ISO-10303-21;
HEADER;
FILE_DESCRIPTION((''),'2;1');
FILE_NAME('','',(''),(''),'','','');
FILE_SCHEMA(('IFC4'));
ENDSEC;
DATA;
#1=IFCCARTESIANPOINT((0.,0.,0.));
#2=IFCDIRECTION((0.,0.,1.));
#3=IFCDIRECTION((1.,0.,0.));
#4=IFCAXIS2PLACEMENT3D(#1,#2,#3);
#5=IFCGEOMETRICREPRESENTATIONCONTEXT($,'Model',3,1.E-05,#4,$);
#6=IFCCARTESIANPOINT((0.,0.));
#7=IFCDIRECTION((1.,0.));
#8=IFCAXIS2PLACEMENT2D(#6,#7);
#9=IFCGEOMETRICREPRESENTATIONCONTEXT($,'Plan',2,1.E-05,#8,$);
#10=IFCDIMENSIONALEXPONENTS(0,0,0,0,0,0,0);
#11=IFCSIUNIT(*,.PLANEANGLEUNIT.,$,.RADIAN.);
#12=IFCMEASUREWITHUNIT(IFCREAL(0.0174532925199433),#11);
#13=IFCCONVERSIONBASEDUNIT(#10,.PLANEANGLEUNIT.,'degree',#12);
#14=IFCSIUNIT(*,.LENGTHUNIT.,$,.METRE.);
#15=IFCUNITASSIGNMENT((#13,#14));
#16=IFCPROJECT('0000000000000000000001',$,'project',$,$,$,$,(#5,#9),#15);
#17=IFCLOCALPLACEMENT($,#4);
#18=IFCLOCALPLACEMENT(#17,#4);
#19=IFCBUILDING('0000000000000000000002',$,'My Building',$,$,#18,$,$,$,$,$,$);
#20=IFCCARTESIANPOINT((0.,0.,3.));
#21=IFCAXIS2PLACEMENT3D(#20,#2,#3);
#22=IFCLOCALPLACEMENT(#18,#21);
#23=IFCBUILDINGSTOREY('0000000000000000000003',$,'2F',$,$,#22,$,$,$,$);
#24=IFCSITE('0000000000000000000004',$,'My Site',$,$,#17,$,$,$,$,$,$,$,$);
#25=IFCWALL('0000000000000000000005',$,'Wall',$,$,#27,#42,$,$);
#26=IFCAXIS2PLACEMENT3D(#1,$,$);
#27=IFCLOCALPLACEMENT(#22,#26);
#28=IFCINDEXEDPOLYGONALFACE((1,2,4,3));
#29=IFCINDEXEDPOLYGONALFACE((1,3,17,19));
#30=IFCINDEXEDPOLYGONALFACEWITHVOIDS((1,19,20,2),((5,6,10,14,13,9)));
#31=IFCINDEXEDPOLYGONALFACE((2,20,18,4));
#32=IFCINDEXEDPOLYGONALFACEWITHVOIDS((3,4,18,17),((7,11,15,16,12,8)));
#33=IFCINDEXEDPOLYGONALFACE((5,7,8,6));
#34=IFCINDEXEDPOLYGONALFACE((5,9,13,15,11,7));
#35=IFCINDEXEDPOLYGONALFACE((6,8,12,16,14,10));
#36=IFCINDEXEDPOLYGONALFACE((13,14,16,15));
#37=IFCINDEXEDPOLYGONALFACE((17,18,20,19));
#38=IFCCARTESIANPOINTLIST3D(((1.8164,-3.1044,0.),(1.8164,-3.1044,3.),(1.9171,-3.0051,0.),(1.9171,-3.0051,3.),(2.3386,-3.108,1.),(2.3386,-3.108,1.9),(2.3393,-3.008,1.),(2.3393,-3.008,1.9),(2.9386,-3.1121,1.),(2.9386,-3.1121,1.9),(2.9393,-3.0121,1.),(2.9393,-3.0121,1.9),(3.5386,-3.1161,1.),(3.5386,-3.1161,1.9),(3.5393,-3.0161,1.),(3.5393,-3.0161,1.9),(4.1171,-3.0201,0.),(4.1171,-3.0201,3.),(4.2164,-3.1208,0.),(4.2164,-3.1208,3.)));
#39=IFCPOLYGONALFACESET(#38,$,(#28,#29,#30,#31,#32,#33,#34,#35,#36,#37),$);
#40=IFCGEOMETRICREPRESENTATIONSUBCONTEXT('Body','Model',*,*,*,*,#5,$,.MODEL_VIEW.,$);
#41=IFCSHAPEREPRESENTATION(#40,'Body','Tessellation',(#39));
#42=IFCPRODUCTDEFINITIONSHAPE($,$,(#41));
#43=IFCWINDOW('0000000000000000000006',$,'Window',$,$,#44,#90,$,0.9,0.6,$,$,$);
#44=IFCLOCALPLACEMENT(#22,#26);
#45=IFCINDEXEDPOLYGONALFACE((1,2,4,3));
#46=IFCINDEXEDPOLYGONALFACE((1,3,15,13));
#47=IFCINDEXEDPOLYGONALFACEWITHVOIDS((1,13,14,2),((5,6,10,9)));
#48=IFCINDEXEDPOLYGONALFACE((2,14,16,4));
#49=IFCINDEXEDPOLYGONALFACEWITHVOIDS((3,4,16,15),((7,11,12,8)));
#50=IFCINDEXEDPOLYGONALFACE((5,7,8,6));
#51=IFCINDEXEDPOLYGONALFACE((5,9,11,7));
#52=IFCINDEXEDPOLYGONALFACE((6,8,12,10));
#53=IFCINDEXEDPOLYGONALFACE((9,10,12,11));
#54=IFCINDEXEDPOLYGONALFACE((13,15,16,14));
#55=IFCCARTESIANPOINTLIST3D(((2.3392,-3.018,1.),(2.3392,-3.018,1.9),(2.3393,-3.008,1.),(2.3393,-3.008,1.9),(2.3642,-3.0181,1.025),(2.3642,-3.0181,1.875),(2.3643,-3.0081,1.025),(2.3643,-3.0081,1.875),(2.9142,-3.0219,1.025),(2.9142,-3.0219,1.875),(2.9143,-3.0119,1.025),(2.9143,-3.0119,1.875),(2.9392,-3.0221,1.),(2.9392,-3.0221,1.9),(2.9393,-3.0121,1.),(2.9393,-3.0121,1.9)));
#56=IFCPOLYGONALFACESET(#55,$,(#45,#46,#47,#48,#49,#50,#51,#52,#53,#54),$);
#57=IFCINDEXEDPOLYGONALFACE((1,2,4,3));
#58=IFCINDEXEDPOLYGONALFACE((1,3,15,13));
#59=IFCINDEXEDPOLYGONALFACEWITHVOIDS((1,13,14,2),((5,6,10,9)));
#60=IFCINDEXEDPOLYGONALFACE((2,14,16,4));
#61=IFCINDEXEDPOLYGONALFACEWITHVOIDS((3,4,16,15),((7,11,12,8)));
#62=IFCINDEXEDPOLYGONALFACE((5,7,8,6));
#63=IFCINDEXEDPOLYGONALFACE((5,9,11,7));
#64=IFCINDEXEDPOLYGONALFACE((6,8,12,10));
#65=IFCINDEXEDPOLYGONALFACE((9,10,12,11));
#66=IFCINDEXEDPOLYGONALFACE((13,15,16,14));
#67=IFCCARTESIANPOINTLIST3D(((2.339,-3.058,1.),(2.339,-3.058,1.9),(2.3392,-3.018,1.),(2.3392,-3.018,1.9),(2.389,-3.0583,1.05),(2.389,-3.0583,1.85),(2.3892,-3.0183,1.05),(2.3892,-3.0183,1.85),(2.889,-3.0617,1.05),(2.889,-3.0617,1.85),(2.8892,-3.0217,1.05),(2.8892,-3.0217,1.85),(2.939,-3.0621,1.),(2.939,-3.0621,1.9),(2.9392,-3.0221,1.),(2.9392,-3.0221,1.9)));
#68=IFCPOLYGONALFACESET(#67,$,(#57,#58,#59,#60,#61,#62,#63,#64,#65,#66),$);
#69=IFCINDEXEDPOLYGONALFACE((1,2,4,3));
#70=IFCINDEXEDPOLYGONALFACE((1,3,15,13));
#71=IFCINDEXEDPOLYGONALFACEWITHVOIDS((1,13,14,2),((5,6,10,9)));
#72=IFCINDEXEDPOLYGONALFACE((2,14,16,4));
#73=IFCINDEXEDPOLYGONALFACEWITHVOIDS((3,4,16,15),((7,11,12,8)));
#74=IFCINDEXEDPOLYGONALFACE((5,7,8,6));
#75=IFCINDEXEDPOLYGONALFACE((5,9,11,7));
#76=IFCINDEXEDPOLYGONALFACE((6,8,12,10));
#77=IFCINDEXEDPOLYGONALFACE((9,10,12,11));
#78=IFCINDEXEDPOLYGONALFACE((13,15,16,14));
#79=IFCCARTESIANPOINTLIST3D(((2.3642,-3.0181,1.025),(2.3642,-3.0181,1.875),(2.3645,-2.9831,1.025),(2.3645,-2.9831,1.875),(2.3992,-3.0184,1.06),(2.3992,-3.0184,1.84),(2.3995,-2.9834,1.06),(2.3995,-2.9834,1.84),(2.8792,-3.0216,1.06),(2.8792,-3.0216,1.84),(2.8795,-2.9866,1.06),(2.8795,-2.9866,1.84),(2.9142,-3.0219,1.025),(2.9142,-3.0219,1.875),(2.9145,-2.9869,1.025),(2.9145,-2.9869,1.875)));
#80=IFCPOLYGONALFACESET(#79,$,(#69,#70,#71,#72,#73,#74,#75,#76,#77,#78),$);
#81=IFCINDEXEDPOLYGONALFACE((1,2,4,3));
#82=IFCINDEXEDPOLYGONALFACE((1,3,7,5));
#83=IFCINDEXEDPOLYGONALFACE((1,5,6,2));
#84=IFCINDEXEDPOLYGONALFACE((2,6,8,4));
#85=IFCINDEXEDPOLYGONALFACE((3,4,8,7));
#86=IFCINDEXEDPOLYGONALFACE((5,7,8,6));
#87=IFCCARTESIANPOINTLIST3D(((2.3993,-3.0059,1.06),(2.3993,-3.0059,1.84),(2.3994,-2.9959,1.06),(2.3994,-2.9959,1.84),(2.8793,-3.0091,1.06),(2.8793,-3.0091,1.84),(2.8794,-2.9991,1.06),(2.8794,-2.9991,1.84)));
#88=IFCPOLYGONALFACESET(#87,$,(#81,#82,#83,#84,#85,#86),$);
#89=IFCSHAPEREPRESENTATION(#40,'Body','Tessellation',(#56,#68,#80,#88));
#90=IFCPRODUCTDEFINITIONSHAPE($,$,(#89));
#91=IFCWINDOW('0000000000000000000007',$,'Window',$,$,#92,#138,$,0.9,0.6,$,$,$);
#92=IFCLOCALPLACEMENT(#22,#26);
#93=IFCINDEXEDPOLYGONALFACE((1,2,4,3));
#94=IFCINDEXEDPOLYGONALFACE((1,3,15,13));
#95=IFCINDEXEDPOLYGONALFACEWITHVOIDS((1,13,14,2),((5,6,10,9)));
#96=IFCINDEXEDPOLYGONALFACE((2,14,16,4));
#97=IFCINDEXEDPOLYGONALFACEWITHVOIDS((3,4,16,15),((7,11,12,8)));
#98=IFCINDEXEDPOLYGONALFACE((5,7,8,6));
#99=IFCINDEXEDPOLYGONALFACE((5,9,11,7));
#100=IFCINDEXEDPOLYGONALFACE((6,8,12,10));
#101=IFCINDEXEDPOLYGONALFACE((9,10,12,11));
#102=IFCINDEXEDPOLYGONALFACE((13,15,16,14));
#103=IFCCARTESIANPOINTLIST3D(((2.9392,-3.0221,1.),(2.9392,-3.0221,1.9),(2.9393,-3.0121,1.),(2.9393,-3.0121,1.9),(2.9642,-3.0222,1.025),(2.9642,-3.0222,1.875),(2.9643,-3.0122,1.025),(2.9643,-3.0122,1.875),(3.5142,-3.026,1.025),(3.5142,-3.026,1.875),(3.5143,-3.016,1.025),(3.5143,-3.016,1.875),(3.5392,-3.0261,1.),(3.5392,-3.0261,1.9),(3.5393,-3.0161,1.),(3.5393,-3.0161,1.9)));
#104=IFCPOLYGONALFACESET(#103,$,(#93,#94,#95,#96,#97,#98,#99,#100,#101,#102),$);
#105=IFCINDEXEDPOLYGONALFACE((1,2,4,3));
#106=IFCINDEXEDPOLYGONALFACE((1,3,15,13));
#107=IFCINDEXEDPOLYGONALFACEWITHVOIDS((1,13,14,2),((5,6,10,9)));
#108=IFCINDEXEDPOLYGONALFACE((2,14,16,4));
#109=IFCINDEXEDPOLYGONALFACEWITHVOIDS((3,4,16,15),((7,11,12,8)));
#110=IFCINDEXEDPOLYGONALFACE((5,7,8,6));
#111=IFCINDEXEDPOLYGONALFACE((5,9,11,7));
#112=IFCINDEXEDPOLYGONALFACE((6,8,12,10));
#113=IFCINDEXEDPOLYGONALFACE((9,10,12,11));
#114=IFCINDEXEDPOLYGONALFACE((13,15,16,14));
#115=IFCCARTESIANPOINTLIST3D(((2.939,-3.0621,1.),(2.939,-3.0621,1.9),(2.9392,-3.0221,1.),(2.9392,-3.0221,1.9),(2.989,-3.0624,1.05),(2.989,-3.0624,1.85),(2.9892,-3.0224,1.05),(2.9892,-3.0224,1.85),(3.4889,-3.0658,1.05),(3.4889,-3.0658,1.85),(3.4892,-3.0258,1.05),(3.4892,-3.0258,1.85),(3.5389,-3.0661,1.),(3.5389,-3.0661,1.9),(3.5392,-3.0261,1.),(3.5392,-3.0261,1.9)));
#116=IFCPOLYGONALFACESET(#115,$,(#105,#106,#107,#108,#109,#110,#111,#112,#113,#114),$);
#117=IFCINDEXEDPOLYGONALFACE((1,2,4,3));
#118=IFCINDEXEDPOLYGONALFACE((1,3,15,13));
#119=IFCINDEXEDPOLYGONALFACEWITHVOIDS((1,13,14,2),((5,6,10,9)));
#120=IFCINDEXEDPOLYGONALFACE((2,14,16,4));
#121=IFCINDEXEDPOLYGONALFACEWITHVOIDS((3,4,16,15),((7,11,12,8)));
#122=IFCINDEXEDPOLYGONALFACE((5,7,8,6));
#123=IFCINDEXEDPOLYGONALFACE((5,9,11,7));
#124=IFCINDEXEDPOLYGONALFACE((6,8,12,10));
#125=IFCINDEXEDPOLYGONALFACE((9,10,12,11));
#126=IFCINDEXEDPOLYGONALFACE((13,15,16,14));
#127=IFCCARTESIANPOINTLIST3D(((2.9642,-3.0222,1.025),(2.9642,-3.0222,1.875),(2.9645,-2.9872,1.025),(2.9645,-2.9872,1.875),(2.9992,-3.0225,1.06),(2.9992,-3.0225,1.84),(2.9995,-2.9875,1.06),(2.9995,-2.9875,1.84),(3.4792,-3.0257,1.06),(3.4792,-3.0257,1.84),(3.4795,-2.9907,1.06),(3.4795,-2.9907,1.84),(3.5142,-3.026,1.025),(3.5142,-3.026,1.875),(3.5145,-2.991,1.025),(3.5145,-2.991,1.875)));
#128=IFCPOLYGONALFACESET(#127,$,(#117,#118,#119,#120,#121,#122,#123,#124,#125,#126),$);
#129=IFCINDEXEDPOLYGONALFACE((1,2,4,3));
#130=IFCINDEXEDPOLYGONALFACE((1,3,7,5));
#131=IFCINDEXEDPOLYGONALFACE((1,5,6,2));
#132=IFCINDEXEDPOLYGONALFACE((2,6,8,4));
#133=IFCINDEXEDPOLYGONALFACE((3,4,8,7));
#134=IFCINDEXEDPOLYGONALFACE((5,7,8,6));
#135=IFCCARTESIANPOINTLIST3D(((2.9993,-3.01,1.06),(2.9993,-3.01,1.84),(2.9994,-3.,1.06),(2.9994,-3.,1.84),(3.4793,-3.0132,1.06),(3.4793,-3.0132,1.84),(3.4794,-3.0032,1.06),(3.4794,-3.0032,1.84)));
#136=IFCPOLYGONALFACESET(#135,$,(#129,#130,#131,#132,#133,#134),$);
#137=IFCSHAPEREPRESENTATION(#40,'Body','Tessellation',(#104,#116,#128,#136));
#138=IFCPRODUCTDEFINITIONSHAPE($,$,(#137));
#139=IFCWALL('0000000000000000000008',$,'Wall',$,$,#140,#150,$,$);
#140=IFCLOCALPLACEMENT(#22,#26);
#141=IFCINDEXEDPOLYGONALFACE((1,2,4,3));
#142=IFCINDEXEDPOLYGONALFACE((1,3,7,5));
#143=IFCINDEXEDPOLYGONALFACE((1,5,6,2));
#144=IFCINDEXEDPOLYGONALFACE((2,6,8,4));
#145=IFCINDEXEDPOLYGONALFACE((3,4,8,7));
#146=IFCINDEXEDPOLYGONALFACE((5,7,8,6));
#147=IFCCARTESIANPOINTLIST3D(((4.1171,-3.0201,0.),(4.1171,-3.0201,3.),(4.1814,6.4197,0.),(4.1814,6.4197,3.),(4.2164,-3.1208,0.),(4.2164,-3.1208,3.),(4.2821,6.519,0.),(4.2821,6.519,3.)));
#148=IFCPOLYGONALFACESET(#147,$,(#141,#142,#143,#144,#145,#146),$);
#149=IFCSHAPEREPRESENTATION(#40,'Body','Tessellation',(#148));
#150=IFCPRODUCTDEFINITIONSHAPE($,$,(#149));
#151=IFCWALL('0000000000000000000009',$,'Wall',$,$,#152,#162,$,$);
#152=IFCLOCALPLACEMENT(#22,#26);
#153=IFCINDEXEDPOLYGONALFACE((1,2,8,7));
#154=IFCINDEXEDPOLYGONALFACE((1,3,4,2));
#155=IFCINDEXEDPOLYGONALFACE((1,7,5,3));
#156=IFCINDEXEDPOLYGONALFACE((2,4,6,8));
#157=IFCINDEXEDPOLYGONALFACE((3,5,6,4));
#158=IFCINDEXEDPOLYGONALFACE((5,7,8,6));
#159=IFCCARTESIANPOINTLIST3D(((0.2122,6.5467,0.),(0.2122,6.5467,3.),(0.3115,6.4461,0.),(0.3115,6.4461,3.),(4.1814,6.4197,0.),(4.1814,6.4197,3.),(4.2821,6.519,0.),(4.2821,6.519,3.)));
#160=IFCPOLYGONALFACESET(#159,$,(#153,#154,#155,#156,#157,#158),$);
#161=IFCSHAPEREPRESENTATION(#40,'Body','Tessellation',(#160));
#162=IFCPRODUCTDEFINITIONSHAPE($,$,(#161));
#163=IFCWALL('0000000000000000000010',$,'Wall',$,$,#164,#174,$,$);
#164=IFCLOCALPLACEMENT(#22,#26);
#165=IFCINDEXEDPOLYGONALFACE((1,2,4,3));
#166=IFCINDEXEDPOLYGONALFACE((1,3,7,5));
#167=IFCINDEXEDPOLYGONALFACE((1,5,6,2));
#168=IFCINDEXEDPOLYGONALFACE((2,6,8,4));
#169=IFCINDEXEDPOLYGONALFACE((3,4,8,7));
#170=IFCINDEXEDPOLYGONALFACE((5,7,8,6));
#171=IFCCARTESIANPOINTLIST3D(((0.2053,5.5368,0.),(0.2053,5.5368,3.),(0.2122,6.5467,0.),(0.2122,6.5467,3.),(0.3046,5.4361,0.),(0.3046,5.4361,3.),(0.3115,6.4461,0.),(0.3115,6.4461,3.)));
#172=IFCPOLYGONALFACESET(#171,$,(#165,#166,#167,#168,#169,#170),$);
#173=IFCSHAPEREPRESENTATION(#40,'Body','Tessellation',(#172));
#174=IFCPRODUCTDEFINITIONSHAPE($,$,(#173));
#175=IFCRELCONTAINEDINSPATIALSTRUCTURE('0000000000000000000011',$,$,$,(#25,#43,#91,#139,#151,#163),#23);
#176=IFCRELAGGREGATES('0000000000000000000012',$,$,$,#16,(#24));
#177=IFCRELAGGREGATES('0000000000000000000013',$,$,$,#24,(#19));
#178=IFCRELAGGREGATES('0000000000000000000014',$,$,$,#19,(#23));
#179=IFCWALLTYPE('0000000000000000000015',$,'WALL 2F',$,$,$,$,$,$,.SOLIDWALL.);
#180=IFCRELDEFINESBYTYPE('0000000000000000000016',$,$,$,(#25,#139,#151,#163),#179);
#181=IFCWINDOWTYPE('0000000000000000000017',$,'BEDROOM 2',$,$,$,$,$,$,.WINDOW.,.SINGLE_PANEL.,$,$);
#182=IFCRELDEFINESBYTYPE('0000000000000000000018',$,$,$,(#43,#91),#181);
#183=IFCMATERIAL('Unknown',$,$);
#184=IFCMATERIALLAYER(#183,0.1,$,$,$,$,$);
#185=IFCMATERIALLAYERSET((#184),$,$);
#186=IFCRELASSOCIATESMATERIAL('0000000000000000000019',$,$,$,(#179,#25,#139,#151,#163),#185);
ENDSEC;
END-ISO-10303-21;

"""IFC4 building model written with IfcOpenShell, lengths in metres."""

from ifc_helpers import new_model, entity, si_unit, converted_unit, frame, origin_with_axes, origin_2d_with_axis, place, context, subcontext, project, spatial, line, indexed_curve, outline, extrude, shape, source, transform, mapped, material, layer, layer_set, layer_usage, type_object, type_shapes, element, fill, save


model = new_model("IFC4")

# Units and contexts
model_context = context("Model", 3, precision=1e-05, world=origin_with_axes())
plan_context = context("Plan", 2, precision=1e-05, world=origin_2d_with_axis())
body_context_1 = subcontext(model_context, "Body", "Model", "MODEL_VIEW")
body_context_2 = subcontext(plan_context, "Body", "Plan", "PLAN_VIEW")
ifc_project = project(units=[converted_unit("PLANEANGLEUNIT", "degree", entity("IfcReal", 0.0174532925199433), si_unit("PLANEANGLEUNIT", "RADIAN"), dimensions=[0, 0, 0, 0, 0, 0, 0]), si_unit("LENGTHUNIT", "METRE")], contexts=[model_context, plan_context])

# Site, building, storey
site_placement = place(None, origin_with_axes())
site = spatial("IfcSite", under=ifc_project, at=site_placement, Name="My Site")
building_placement = place(site_placement, origin_with_axes())
building = spatial("IfcBuilding", under=site, at=building_placement, Name="My Building")
storey_placement = place(building_placement, frame((0.0, 0.0, 3.0), z_axis=(0.0, 0.0, 1.0), x_axis=(1.0, 0.0, 0.0)))
storey = spatial("IfcBuildingStorey", under=building, at=storey_placement, Name="2F")

# Shared definitions
ifc_material = material(Name="Unknown")

# Shared definitions
ifc_layer_1 = layer(ifc_material, 0.1)
ifc_layer_set_1 = layer_set([ifc_layer_1])
wall_type = type_object("IfcWallType", Name="WALL 2F", PredefinedType="SOLIDWALL", material=ifc_layer_set_1)

# Wall, openings, windows
ifc_layer_usage_1 = layer_usage(ifc_layer_set_1, "AXIS2", "POSITIVE", 0.0)
wall_1_placement = place(storey_placement, frame((1.8164, -3.1044, 0.0), z_axis=(0.0, 0.0, 1.0), x_axis=(0.999977, -0.006814, 0.0)))
wall_1 = element("IfcWall", 1, at=wall_1_placement, inside=storey, type_object=wall_type, material=ifc_layer_usage_1, Name="Wall", context=body_context_1, shape_type="SweptSolid", body=[
    extrude(outline(indexed_curve([(0.0, 0.0), (0.1, 0.1), (2.3, 0.1), (2.4, 0.0)], segments=[line(1, 2, 3, 4, 1)])), origin_with_axes(), (0.0, 0.0, 1.0), 3.0),
])
shared_shape_1 = source(origin_with_axes(), body_context_1, "Body", "SweptSolid", [
    extrude(outline(indexed_curve([(0.0, 0.0), (0.6, 0.0), (0.6, 0.9), (0.0, 0.9)], segments=[line(1, 2, 3, 4, 1)])), frame((0.0, -0.6, 0.0), z_axis=(0.0, -1.0, 0.0), x_axis=(1.0, 0.0, 0.0)), (0.0, 0.0, -1.0), 1.2),
])
opening_1_placement = place(wall_1_placement, frame((0.5222, 0.0, 1.0), z_axis=(0.0, 0.0, 1.0), x_axis=(1.0, 0.0, 0.0)))
opening_1 = element("IfcOpeningElement", 2, at=opening_1_placement, cuts=wall_1, PredefinedType="OPENING", context=body_context_1, shape_type="MappedRepresentation", body=[
    mapped(shared_shape_1, transform((0.0, 0.0, 0.0), x_axis=(1.0, 0.0, 0.0), y_axis=(0.0, 1.0, 0.0), z_axis=(0.0, 0.0, 1.0), scale=1.0)),
])
opening_2_placement = place(wall_1_placement, frame((1.1222, 0.0, 1.0), z_axis=(0.0, 0.0, 1.0), x_axis=(1.0, 0.0, 0.0)))
opening_2 = element("IfcOpeningElement", 3, at=opening_2_placement, cuts=wall_1, PredefinedType="OPENING", context=body_context_1, shape_type="MappedRepresentation", body=[
    mapped(shared_shape_1, transform((0.0, 0.0, 0.0), x_axis=(1.0, 0.0, 0.0), y_axis=(0.0, 1.0, 0.0), z_axis=(0.0, 0.0, 1.0), scale=1.0)),
])
window_type_1 = type_object("IfcWindowType", Name="BEDROOM 2", PartitioningType="SINGLE_PANEL", PredefinedType="WINDOW")
shared_shape_2 = source(origin_with_axes(), body_context_1, "Body", "SweptSolid", [
    extrude(outline(indexed_curve([(0.0, 0.0), (0.6, 0.0), (0.6, 0.9), (0.0, 0.9)], segments=[line(1, 2, 3, 4, 1)]), holes=[indexed_curve([(0.025, 0.025), (0.575, 0.025), (0.575, 0.875), (0.025, 0.875)], segments=[line(1, 2, 3, 4, 1)])]), frame((0.0, 0.09, 0.0), z_axis=(0.0, -1.0, 0.0), x_axis=(1.0, 0.0, 0.0)), (0.0, 0.0, -1.0), 0.01),
    extrude(outline(indexed_curve([(0.0, 0.0), (0.6, 0.0), (0.6, 0.9), (0.0, 0.9)], segments=[line(1, 2, 3, 4, 1)]), holes=[indexed_curve([(0.05, 0.05), (0.55, 0.05), (0.55, 0.85), (0.05, 0.85)], segments=[line(1, 2, 3, 4, 1)])]), frame((0.0, 0.05, 0.0), z_axis=(0.0, -1.0, 0.0), x_axis=(1.0, 0.0, 0.0)), (0.0, 0.0, -1.0), 0.04),
    extrude(outline(indexed_curve([(0.0, 0.0), (0.55, 0.0), (0.55, 0.85), (0.0, 0.85)], segments=[line(1, 2, 3, 4, 1)]), holes=[indexed_curve([(0.035, 0.035), (0.515, 0.035), (0.515, 0.815), (0.035, 0.815)], segments=[line(1, 2, 3, 4, 1)])]), frame((0.025, 0.09, 0.025), z_axis=(0.0, -1.0, 0.0), x_axis=(1.0, 0.0, 0.0)), (0.0, 0.0, -1.0), 0.035),
    extrude(outline(indexed_curve([(0.035, 0.035), (0.515, 0.035), (0.515, 0.815), (0.035, 0.815)], segments=[line(1, 2, 3, 4, 1)])), frame((0.025, 0.1025, 0.025), z_axis=(0.0, -1.0, 0.0), x_axis=(1.0, 0.0, 0.0)), (0.0, 0.0, -1.0), 0.01),
])
shared_shape_3 = source(origin_with_axes(), body_context_2, "Body", "Curve2D", [
    entity("IfcIndexedPolyCurve", entity("IfcCartesianPointList2D", [[0.05, 0.05], [0.55, 0.05]])),
    entity("IfcIndexedPolyCurve", entity("IfcCartesianPointList2D", [[0.0, 0.1], [0.025, 0.1], [0.025, 0.09], [0.05, 0.09], [0.05, 0.05], [0.0, 0.05]]), [entity("IfcLineIndex", [1, 2, 3, 4, 5, 6, 1])]),
    entity("IfcIndexedPolyCurve", entity("IfcCartesianPointList2D", [[0.6, 0.1], [0.575, 0.1], [0.575, 0.09], [0.55, 0.09], [0.55, 0.05], [0.6, 0.05]]), [entity("IfcLineIndex", [1, 2, 3, 4, 5, 6, 1])]),
    entity("IfcIndexedPolyCurve", entity("IfcCartesianPointList2D", [[0.025, 0.09], [0.06, 0.09], [0.06, 0.125], [0.025, 0.125]]), [entity("IfcLineIndex", [1, 2, 3, 4, 1])]),
    entity("IfcIndexedPolyCurve", entity("IfcCartesianPointList2D", [[0.575, 0.09], [0.54, 0.09], [0.54, 0.125], [0.575, 0.125]]), [entity("IfcLineIndex", [1, 2, 3, 4, 1])]),
    entity("IfcIndexedPolyCurve", entity("IfcCartesianPointList2D", [[0.06, 0.09], [0.54, 0.09]])),
    entity("IfcIndexedPolyCurve", entity("IfcCartesianPointList2D", [[0.06, 0.125], [0.54, 0.125]])),
    entity("IfcIndexedPolyCurve", entity("IfcCartesianPointList2D", [[0.06, 0.1075], [0.54, 0.1075]])),
])
type_shapes(window_type_1, [shared_shape_2, shared_shape_3])
window_1_placement = place(opening_1_placement, frame((0.0, 0.0, 0.0), z_axis=(0.0, 0.0, 1.0), x_axis=(1.0, 0.0, 0.0)))
window_1 = element("IfcWindow", 4, at=window_1_placement, inside=storey, type_object=window_type_1, Name="Window", OverallHeight=0.9, OverallWidth=0.6, shapes=[
    shape(body_context_1, "Body", "MappedRepresentation", [mapped(shared_shape_2, transform((0.0, 0.0, 0.0), x_axis=(1.0, 0.0, 0.0), y_axis=(0.0, 1.0, 0.0), z_axis=(0.0, 0.0, 1.0), scale=1.0))]),
    shape(body_context_2, "Body", "MappedRepresentation", [mapped(shared_shape_3, transform((0.0, 0.0, 0.0), x_axis=(1.0, 0.0, 0.0), y_axis=(0.0, 1.0, 0.0), z_axis=(0.0, 0.0, 1.0), scale=1.0))]),
])
fill(opening_1, window_1)
window_2_placement = place(opening_2_placement, frame((0.0, 0.0, 0.0), z_axis=(0.0, 0.0, 1.0), x_axis=(1.0, 0.0, 0.0)))
window_2 = element("IfcWindow", 5, at=window_2_placement, inside=storey, type_object=window_type_1, Name="Window", OverallHeight=0.9, OverallWidth=0.6, shapes=[
    shape(body_context_1, "Body", "MappedRepresentation", [mapped(shared_shape_2, transform((0.0, 0.0, 0.0), x_axis=(1.0, 0.0, 0.0), y_axis=(0.0, 1.0, 0.0), z_axis=(0.0, 0.0, 1.0), scale=1.0))]),
    shape(body_context_2, "Body", "MappedRepresentation", [mapped(shared_shape_3, transform((0.0, 0.0, 0.0), x_axis=(1.0, 0.0, 0.0), y_axis=(0.0, 1.0, 0.0), z_axis=(0.0, 0.0, 1.0), scale=1.0))]),
])
fill(opening_2, window_2)

# Walls
ifc_layer_usage_2 = layer_usage(ifc_layer_set_1, "AXIS2", "POSITIVE", 0.0)
wall_2_placement = place(storey_placement, frame((4.2164, -3.1208, 0.0), z_axis=(0.0, 0.0, 1.0), x_axis=(0.006815, 0.999977, 0.0)))
element("IfcWall", 6, at=wall_2_placement, inside=storey, type_object=wall_type, material=ifc_layer_usage_2, Name="Wall", context=body_context_1, shape_type="SweptSolid", body=[
    extrude(outline(indexed_curve([(0.0, 0.0), (0.1, 0.1), (9.54, 0.1), (9.64, 0.0)], segments=[line(1, 2, 3, 4, 1)])), origin_with_axes(), (0.0, 0.0, 1.0), 3.0),
])
ifc_layer_usage_3 = layer_usage(ifc_layer_set_1, "AXIS2", "POSITIVE", 0.0)
wall_3_placement = place(storey_placement, frame((4.2821, 6.519, 0.0), z_axis=(0.0, 0.0, 1.0), x_axis=(-0.999977, 0.006814, 0.0)))
element("IfcWall", 7, at=wall_3_placement, inside=storey, type_object=wall_type, material=ifc_layer_usage_3, Name="Wall", context=body_context_1, shape_type="SweptSolid", body=[
    extrude(outline(indexed_curve([(0.0, 0.0), (0.1, 0.1), (3.97, 0.1), (4.07, 0.0)], segments=[line(1, 2, 3, 4, 1)])), origin_with_axes(), (0.0, 0.0, 1.0), 3.0),
])
ifc_layer_usage_4 = layer_usage(ifc_layer_set_1, "AXIS2", "POSITIVE", 0.0)
wall_4_placement = place(storey_placement, frame((0.2122, 6.5467, 0.0), z_axis=(0.0, 0.0, 1.0), x_axis=(-0.006815, -0.999977, 0.0)))
element("IfcWall", 8, at=wall_4_placement, inside=storey, type_object=wall_type, material=ifc_layer_usage_4, Name="Wall", context=body_context_1, shape_type="SweptSolid", body=[
    extrude(outline(indexed_curve([(0.0, 0.0), (0.1, 0.1), (1.11, 0.1), (1.01, 0.0)], segments=[line(1, 2, 3, 4, 1)])), origin_with_axes(), (0.0, 0.0, 1.0), 3.0),
])

save(model, "model.ifc")
